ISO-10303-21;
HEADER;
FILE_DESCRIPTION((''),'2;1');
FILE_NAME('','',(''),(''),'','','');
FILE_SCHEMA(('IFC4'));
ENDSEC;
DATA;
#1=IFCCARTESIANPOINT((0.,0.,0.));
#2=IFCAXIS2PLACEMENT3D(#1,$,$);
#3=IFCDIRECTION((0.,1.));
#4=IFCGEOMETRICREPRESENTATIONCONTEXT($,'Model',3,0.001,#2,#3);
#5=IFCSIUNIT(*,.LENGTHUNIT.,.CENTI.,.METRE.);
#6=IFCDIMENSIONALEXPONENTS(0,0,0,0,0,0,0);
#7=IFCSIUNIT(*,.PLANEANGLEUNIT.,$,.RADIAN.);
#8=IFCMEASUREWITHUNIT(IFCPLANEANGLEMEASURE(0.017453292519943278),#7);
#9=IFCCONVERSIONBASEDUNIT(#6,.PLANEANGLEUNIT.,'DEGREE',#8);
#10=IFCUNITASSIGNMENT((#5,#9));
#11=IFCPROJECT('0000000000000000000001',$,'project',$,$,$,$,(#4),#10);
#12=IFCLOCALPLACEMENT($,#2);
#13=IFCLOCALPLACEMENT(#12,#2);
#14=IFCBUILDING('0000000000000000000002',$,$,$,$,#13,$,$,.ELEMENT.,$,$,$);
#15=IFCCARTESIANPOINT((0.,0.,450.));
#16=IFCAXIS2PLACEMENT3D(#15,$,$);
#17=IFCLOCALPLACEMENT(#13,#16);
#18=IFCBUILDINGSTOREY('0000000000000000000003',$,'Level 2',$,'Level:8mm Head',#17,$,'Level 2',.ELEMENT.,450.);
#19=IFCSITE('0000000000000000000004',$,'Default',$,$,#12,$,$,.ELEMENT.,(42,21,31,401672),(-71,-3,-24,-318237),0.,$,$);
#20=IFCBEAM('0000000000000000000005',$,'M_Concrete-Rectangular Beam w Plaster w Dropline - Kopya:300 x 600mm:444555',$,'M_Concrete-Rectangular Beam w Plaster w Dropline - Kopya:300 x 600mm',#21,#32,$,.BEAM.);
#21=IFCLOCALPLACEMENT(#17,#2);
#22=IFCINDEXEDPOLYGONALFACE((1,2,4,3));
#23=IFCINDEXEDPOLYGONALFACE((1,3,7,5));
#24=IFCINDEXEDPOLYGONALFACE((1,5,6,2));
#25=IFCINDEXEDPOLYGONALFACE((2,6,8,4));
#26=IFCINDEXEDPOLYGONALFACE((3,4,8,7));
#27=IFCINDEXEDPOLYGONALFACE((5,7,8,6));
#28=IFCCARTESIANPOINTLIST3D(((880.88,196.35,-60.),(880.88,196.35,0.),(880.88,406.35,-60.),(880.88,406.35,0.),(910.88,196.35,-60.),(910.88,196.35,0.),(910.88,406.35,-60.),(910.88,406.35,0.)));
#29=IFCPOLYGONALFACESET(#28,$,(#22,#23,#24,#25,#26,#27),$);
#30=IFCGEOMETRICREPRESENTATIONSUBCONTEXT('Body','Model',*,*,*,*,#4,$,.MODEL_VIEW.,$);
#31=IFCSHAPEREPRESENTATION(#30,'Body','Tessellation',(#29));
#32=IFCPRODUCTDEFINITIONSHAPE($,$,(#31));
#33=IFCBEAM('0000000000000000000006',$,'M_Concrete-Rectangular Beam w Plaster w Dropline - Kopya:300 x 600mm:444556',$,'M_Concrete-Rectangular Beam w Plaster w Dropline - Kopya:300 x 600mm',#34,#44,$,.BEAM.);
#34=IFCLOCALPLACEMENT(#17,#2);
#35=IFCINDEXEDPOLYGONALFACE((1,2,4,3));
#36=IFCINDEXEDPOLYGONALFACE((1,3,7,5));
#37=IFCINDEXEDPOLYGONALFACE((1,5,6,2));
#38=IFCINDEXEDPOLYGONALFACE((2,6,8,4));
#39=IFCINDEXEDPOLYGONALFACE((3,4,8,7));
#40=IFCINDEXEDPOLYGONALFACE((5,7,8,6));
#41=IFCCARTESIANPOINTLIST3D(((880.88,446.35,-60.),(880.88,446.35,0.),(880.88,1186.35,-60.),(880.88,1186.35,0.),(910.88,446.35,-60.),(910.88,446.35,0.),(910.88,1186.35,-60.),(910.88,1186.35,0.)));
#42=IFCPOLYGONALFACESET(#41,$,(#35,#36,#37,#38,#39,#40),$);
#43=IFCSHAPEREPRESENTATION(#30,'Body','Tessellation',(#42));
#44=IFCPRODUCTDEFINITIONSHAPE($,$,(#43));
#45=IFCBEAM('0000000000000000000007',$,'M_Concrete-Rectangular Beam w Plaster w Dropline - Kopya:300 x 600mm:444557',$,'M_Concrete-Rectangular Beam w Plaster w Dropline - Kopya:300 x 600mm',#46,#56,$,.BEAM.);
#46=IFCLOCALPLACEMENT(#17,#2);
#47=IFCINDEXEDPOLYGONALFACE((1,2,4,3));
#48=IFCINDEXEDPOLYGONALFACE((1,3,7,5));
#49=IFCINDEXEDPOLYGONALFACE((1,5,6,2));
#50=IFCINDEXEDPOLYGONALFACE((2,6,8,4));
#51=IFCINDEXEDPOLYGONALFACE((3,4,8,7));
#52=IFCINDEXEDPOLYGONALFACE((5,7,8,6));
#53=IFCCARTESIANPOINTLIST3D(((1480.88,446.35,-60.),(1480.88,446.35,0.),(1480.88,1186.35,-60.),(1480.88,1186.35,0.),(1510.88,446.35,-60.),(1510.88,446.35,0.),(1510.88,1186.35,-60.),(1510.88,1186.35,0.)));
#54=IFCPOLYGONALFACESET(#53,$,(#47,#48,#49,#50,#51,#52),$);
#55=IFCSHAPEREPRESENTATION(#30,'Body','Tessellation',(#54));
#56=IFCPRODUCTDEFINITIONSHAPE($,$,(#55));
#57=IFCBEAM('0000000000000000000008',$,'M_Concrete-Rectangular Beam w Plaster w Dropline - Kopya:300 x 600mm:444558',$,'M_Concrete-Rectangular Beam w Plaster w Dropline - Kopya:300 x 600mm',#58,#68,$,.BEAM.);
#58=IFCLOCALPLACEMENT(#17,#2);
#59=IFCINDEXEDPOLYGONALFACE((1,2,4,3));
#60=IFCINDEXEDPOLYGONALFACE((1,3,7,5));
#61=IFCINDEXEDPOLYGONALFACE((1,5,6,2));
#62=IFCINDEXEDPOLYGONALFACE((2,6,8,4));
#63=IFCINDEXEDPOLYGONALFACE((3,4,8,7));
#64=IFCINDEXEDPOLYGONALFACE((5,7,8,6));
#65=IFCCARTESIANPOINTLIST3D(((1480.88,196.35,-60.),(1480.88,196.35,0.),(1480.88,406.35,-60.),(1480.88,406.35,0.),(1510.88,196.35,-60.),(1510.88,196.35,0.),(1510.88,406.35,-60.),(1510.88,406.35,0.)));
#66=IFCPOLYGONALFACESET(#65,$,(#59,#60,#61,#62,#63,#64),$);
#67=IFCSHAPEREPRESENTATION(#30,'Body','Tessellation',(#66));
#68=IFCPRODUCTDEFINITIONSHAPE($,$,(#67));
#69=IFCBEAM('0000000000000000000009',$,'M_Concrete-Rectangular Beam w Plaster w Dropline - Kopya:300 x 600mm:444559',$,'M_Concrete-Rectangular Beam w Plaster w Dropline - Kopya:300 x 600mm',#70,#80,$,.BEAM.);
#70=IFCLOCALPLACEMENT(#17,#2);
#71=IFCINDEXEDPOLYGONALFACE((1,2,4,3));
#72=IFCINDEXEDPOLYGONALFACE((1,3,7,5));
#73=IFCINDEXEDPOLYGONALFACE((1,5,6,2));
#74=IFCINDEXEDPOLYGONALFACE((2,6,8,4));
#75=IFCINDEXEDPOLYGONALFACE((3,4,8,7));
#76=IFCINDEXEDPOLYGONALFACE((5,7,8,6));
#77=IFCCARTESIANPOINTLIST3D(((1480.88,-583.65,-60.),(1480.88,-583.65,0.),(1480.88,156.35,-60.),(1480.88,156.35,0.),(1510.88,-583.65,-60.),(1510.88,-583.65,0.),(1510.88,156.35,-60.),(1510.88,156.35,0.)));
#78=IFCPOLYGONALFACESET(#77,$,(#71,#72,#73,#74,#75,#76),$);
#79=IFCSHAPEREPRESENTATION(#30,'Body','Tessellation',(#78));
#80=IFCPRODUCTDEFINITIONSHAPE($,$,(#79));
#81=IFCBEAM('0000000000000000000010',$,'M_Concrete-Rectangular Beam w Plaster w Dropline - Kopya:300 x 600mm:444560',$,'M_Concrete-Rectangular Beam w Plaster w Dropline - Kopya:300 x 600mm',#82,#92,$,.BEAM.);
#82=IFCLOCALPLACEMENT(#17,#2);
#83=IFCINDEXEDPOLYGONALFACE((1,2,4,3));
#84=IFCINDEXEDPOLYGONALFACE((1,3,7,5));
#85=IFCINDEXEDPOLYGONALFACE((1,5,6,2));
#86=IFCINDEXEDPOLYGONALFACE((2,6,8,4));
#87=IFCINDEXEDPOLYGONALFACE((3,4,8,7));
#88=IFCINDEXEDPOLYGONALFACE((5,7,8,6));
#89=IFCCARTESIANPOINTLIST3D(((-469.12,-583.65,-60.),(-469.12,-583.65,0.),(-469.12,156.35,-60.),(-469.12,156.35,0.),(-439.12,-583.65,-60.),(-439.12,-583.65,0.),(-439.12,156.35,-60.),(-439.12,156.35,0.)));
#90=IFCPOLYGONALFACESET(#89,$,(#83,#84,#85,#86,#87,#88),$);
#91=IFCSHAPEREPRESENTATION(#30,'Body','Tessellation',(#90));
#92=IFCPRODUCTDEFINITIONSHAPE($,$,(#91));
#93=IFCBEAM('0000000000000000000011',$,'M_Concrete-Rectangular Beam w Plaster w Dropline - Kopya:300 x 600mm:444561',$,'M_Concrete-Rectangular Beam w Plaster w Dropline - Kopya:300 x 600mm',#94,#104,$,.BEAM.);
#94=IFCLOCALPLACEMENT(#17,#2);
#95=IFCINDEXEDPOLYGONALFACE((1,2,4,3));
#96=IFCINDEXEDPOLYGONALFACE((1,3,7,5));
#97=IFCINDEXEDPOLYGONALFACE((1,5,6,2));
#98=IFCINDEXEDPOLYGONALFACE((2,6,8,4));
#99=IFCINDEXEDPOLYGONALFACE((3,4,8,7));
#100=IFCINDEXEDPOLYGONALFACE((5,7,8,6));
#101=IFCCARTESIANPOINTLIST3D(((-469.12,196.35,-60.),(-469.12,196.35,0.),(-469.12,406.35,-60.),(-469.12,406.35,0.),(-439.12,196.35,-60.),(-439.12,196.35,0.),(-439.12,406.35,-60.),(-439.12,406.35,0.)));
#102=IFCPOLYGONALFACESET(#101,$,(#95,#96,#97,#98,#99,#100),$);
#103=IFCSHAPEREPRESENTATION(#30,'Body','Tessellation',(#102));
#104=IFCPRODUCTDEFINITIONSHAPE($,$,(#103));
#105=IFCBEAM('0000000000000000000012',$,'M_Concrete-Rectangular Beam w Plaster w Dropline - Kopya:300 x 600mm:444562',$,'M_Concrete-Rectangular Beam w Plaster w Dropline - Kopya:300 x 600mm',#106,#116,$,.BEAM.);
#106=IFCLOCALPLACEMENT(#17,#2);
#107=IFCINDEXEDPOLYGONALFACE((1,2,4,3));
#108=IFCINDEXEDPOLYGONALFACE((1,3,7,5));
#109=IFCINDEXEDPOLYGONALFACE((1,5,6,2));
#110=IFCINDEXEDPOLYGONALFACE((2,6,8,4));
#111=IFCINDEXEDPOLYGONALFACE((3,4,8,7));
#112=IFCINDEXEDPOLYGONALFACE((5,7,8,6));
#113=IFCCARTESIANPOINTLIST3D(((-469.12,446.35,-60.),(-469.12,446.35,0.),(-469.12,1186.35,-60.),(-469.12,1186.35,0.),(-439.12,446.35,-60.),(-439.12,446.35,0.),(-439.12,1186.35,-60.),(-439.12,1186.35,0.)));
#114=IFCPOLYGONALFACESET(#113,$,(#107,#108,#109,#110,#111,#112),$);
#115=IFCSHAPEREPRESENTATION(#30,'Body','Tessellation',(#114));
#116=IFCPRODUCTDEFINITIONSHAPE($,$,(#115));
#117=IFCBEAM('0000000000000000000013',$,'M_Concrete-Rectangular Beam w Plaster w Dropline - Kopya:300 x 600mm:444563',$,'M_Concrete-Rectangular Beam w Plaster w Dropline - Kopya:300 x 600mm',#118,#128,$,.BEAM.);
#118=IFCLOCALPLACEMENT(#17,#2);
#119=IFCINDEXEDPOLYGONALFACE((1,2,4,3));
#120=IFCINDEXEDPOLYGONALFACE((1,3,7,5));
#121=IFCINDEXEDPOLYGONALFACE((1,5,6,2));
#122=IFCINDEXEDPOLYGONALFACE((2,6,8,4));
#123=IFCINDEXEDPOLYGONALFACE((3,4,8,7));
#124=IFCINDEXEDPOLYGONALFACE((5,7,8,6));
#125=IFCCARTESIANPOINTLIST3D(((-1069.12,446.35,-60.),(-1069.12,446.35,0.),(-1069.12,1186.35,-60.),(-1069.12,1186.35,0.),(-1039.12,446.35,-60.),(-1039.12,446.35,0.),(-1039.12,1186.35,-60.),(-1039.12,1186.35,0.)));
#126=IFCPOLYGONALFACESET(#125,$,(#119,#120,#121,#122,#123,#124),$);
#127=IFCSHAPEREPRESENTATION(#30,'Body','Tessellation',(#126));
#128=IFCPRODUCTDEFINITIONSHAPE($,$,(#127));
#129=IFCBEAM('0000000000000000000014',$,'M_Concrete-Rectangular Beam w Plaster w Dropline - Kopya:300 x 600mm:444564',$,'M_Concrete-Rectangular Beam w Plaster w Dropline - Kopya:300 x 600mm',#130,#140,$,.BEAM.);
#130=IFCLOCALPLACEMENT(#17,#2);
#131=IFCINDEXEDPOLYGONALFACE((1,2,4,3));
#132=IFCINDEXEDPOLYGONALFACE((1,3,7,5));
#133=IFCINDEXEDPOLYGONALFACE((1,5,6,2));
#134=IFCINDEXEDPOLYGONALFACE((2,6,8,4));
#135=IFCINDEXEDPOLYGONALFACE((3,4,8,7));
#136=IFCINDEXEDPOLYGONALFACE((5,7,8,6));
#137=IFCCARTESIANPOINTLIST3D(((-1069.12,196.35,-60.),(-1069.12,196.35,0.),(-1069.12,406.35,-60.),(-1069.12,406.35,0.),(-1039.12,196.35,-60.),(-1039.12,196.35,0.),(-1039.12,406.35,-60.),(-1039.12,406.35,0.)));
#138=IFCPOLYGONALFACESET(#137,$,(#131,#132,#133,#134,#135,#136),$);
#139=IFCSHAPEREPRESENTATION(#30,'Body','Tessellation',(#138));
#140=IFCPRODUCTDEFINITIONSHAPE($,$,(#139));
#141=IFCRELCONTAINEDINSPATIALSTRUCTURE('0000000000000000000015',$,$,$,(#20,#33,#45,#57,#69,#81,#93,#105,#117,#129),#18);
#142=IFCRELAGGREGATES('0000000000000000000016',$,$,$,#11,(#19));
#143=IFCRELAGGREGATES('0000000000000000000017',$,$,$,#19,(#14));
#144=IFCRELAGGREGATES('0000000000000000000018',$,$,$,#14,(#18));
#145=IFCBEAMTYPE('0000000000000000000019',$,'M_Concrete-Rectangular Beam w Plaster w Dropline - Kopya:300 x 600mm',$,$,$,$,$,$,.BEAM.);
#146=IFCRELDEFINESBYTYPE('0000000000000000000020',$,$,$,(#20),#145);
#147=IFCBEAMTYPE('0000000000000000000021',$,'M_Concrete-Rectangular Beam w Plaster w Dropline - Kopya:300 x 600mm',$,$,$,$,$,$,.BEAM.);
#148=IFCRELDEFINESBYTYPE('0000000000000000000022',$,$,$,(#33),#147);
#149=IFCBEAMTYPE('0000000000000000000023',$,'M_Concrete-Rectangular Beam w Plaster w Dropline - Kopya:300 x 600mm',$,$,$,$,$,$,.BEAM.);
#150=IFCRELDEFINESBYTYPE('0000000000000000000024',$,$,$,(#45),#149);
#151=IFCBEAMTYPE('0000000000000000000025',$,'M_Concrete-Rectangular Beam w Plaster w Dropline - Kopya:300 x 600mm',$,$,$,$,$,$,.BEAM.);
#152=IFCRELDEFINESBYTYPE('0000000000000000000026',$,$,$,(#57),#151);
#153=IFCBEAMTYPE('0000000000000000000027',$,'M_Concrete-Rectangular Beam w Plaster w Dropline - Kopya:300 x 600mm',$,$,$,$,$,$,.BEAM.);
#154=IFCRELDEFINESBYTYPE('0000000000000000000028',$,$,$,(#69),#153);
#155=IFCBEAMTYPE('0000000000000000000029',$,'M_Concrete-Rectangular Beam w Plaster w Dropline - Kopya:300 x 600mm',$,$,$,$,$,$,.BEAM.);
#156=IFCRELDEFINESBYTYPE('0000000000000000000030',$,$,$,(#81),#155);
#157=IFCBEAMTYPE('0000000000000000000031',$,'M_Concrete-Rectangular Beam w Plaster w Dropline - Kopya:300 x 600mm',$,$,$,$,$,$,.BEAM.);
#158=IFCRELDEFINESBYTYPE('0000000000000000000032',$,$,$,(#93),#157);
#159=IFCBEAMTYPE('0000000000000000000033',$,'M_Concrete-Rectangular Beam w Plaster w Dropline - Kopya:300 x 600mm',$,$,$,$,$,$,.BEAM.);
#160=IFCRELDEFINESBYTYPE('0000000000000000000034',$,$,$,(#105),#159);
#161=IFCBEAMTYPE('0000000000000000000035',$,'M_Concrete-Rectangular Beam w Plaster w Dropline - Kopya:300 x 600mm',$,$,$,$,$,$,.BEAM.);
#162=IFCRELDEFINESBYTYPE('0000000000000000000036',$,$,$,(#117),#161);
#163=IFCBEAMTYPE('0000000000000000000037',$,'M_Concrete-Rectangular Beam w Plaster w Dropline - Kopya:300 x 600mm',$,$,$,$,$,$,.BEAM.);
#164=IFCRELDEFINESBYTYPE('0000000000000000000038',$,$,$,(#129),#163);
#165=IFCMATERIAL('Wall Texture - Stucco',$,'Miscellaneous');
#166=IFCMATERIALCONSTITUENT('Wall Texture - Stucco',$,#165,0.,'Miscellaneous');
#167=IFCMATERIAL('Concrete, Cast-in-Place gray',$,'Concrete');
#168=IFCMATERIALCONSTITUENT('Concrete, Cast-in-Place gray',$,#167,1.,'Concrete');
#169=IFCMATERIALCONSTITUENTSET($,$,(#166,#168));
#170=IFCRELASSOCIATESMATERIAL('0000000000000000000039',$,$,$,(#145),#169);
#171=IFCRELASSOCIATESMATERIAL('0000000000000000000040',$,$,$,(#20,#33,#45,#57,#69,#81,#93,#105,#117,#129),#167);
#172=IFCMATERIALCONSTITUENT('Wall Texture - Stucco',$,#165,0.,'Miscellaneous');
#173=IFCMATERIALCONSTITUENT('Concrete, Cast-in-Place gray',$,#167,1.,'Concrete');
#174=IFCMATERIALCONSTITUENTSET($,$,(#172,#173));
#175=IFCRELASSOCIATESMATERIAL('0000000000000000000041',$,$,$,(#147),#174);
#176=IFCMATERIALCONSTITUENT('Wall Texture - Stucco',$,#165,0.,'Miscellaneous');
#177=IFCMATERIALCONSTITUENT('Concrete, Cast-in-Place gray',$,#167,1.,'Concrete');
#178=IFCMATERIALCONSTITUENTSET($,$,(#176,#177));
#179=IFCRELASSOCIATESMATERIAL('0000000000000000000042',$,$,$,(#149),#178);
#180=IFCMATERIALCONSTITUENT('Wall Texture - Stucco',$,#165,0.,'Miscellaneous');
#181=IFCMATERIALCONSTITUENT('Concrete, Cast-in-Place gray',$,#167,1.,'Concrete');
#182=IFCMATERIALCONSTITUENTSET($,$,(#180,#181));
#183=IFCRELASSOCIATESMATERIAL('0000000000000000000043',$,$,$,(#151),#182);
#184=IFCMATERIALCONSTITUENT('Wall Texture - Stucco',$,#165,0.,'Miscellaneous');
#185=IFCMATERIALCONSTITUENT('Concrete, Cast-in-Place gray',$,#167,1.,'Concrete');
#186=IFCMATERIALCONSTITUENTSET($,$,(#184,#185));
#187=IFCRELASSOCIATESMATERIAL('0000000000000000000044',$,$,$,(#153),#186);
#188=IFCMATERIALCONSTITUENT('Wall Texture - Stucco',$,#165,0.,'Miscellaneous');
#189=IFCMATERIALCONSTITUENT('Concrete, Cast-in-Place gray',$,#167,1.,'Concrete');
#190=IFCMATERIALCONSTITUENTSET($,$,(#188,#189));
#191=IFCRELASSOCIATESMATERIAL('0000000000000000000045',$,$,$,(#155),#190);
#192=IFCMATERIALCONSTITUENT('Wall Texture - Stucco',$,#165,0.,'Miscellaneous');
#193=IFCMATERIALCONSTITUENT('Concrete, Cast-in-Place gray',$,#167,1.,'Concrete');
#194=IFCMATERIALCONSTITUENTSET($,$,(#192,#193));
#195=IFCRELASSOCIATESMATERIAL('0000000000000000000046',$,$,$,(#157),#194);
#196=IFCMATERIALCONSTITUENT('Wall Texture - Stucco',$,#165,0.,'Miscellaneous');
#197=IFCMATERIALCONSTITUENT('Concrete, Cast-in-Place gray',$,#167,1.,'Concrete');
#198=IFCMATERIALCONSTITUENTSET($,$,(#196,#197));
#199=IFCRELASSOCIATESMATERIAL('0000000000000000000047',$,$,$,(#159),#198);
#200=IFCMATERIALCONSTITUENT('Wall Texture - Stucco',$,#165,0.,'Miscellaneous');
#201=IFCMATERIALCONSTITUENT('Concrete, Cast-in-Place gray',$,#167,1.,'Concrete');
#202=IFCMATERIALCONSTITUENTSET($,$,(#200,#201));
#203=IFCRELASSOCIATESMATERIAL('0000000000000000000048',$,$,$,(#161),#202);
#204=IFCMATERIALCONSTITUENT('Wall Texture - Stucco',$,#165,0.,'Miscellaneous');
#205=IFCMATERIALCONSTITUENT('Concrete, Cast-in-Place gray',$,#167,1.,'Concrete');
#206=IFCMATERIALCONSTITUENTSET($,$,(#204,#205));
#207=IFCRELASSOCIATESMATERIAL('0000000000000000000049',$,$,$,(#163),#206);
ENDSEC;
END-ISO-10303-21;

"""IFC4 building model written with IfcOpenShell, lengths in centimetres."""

from ifc_helpers import new_model, entity, si_unit, converted_unit, direction, frame, origin, place, context, subcontext, project, spatial, indexed_curve, outline, extrude, source, transform, mapped, material, constituent, constituent_set, type_object, type_shapes, element, save


model = new_model("IFC4")

# Units and contexts
model_context = context("Model", 3, precision=0.001, world=origin(), true_north=direction((0.0, 1.0)))
body_context = subcontext(model_context, "Body", "Model", "MODEL_VIEW")
ifc_project = project(units=[si_unit("LENGTHUNIT", "METRE", prefix="CENTI"), converted_unit("PLANEANGLEUNIT", "DEGREE", entity("IfcPlaneAngleMeasure", 0.017453292519943278), si_unit("PLANEANGLEUNIT", "RADIAN"), dimensions=[0, 0, 0, 0, 0, 0, 0])], contexts=[model_context])

# Site, building, storey
site_placement = place(None, origin())
site = spatial("IfcSite", under=ifc_project, at=site_placement, Name="Default", CompositionType="ELEMENT", RefLatitude=(42, 21, 31, 401672), RefLongitude=(-71, -3, -24, -318237), RefElevation=0.0)
building_placement = place(site_placement, origin())
building = spatial("IfcBuilding", under=site, at=building_placement, CompositionType="ELEMENT")
storey_placement = place(building_placement, frame((0.0, 0.0, 450.0)))
storey = spatial("IfcBuildingStorey", under=building, at=storey_placement, Name="Level 2", ObjectType="Level:8mm Head", LongName="Level 2", CompositionType="ELEMENT", Elevation=450.0)

# Beams
ifc_material_1 = material(Name="Concrete, Cast-in-Place gray", Category="Concrete")
ifc_material_2 = material(Name="Wall Texture - Stucco", Category="Miscellaneous")
ifc_constituent_1 = constituent(ifc_material_2, Name="Wall Texture - Stucco", Category="Miscellaneous", fraction=0.0)
ifc_constituent_2 = constituent(ifc_material_1, Name="Concrete, Cast-in-Place gray", Category="Concrete", fraction=1.0)
ifc_constituent_set_1 = constituent_set(constituents=[ifc_constituent_1, ifc_constituent_2])
beam_type_1 = type_object("IfcBeamType", Name="M_Concrete-Rectangular Beam w Plaster w Dropline - Kopya:300 x 600mm", PredefinedType="BEAM", material=ifc_constituent_set_1)
shared_shape_1 = source(origin(), body_context, "Body", "SweptSolid", [
    extrude(outline(indexed_curve([(-15.0, -30.0), (15.0, -30.0), (15.0, 30.0), (-15.0, 30.0), (-15.0, -30.0)], self_intersect=False)), frame((895.88, 196.35, 420.0), z_axis=(0.0, 1.0, 0.0), x_axis=(-1.0, 0.0, 0.0)), (0.0, 0.0, 1.0), 210.0),
])
type_shapes(beam_type_1, [shared_shape_1])
beam_1_placement = place(storey_placement, frame((0.0, 0.0, -450.0)))
element("IfcBeam", 1, at=beam_1_placement, inside=storey, type_object=beam_type_1, material=ifc_material_1, Name="M_Concrete-Rectangular Beam w Plaster w Dropline - Kopya:300 x 600mm:444555", ObjectType="M_Concrete-Rectangular Beam w Plaster w Dropline - Kopya:300 x 600mm", PredefinedType="BEAM", context=body_context, shape_type="MappedRepresentation", body=[
    mapped(shared_shape_1, transform((0.0, 0.0, 0.0), scale=1.0)),
])
ifc_constituent_3 = constituent(ifc_material_2, Name="Wall Texture - Stucco", Category="Miscellaneous", fraction=0.0)
ifc_constituent_4 = constituent(ifc_material_1, Name="Concrete, Cast-in-Place gray", Category="Concrete", fraction=1.0)
ifc_constituent_set_2 = constituent_set(constituents=[ifc_constituent_3, ifc_constituent_4])
beam_type_2 = type_object("IfcBeamType", Name="M_Concrete-Rectangular Beam w Plaster w Dropline - Kopya:300 x 600mm", PredefinedType="BEAM", material=ifc_constituent_set_2)
shared_shape_2 = source(origin(), body_context, "Body", "SweptSolid", [
    extrude(outline(indexed_curve([(-15.0, -30.0), (15.0, -30.0), (15.0, 30.0), (-15.0, 30.0), (-15.0, -30.0)], self_intersect=False)), frame((895.88, 446.35, 420.0), z_axis=(0.0, 1.0, 0.0), x_axis=(-1.0, 0.0, 0.0)), (0.0, 0.0, 1.0), 740.0),
])
type_shapes(beam_type_2, [shared_shape_2])
beam_2_placement = place(storey_placement, frame((0.0, 0.0, -450.0)))
element("IfcBeam", 2, at=beam_2_placement, inside=storey, type_object=beam_type_2, material=ifc_material_1, Name="M_Concrete-Rectangular Beam w Plaster w Dropline - Kopya:300 x 600mm:444556", ObjectType="M_Concrete-Rectangular Beam w Plaster w Dropline - Kopya:300 x 600mm", PredefinedType="BEAM", context=body_context, shape_type="MappedRepresentation", body=[
    mapped(shared_shape_2, transform((0.0, 0.0, 0.0), scale=1.0)),
])
ifc_constituent_5 = constituent(ifc_material_2, Name="Wall Texture - Stucco", Category="Miscellaneous", fraction=0.0)
ifc_constituent_6 = constituent(ifc_material_1, Name="Concrete, Cast-in-Place gray", Category="Concrete", fraction=1.0)
ifc_constituent_set_3 = constituent_set(constituents=[ifc_constituent_5, ifc_constituent_6])
beam_type_3 = type_object("IfcBeamType", Name="M_Concrete-Rectangular Beam w Plaster w Dropline - Kopya:300 x 600mm", PredefinedType="BEAM", material=ifc_constituent_set_3)
shared_shape_3 = source(origin(), body_context, "Body", "SweptSolid", [
    extrude(outline(indexed_curve([(-15.0, -30.0), (15.0, -30.0), (15.0, 30.0), (-15.0, 30.0), (-15.0, -30.0)], self_intersect=False)), frame((1495.88, 1186.35, 420.0), z_axis=(0.0, -1.0, 0.0), x_axis=(-1.0, 0.0, 0.0)), (0.0, 0.0, 1.0), 740.0),
])
type_shapes(beam_type_3, [shared_shape_3])
beam_3_placement = place(storey_placement, frame((0.0, 0.0, -450.0)))
element("IfcBeam", 3, at=beam_3_placement, inside=storey, type_object=beam_type_3, material=ifc_material_1, Name="M_Concrete-Rectangular Beam w Plaster w Dropline - Kopya:300 x 600mm:444557", ObjectType="M_Concrete-Rectangular Beam w Plaster w Dropline - Kopya:300 x 600mm", PredefinedType="BEAM", context=body_context, shape_type="MappedRepresentation", body=[
    mapped(shared_shape_3, transform((0.0, 0.0, 0.0), scale=1.0)),
])
ifc_constituent_7 = constituent(ifc_material_2, Name="Wall Texture - Stucco", Category="Miscellaneous", fraction=0.0)
ifc_constituent_8 = constituent(ifc_material_1, Name="Concrete, Cast-in-Place gray", Category="Concrete", fraction=1.0)
ifc_constituent_set_4 = constituent_set(constituents=[ifc_constituent_7, ifc_constituent_8])
beam_type_4 = type_object("IfcBeamType", Name="M_Concrete-Rectangular Beam w Plaster w Dropline - Kopya:300 x 600mm", PredefinedType="BEAM", material=ifc_constituent_set_4)
shared_shape_4 = source(origin(), body_context, "Body", "SweptSolid", [
    extrude(outline(indexed_curve([(-15.0, -30.0), (15.0, -30.0), (15.0, 30.0), (-15.0, 30.0), (-15.0, -30.0)], self_intersect=False)), frame((1495.88, 406.35, 420.0), z_axis=(0.0, -1.0, 0.0), x_axis=(-1.0, 0.0, 0.0)), (0.0, 0.0, 1.0), 210.0),
])
type_shapes(beam_type_4, [shared_shape_4])
beam_4_placement = place(storey_placement, frame((0.0, 0.0, -450.0)))
element("IfcBeam", 4, at=beam_4_placement, inside=storey, type_object=beam_type_4, material=ifc_material_1, Name="M_Concrete-Rectangular Beam w Plaster w Dropline - Kopya:300 x 600mm:444558", ObjectType="M_Concrete-Rectangular Beam w Plaster w Dropline - Kopya:300 x 600mm", PredefinedType="BEAM", context=body_context, shape_type="MappedRepresentation", body=[
    mapped(shared_shape_4, transform((0.0, 0.0, 0.0), scale=1.0)),
])
ifc_constituent_9 = constituent(ifc_material_2, Name="Wall Texture - Stucco", Category="Miscellaneous", fraction=0.0)
ifc_constituent_10 = constituent(ifc_material_1, Name="Concrete, Cast-in-Place gray", Category="Concrete", fraction=1.0)
ifc_constituent_set_5 = constituent_set(constituents=[ifc_constituent_9, ifc_constituent_10])
beam_type_5 = type_object("IfcBeamType", Name="M_Concrete-Rectangular Beam w Plaster w Dropline - Kopya:300 x 600mm", PredefinedType="BEAM", material=ifc_constituent_set_5)
shared_shape_5 = source(origin(), body_context, "Body", "SweptSolid", [
    extrude(outline(indexed_curve([(-15.0, -30.0), (15.0, -30.0), (15.0, 30.0), (-15.0, 30.0), (-15.0, -30.0)], self_intersect=False)), frame((1495.88, 156.35, 420.0), z_axis=(0.0, -1.0, 0.0), x_axis=(-1.0, 0.0, 0.0)), (0.0, 0.0, 1.0), 740.0),
])
type_shapes(beam_type_5, [shared_shape_5])
beam_5_placement = place(storey_placement, frame((0.0, 0.0, -450.0)))
element("IfcBeam", 5, at=beam_5_placement, inside=storey, type_object=beam_type_5, material=ifc_material_1, Name="M_Concrete-Rectangular Beam w Plaster w Dropline - Kopya:300 x 600mm:444559", ObjectType="M_Concrete-Rectangular Beam w Plaster w Dropline - Kopya:300 x 600mm", PredefinedType="BEAM", context=body_context, shape_type="MappedRepresentation", body=[
    mapped(shared_shape_5, transform((0.0, 0.0, 0.0), scale=1.0)),
])
ifc_constituent_11 = constituent(ifc_material_2, Name="Wall Texture - Stucco", Category="Miscellaneous", fraction=0.0)
ifc_constituent_12 = constituent(ifc_material_1, Name="Concrete, Cast-in-Place gray", Category="Concrete", fraction=1.0)
ifc_constituent_set_6 = constituent_set(constituents=[ifc_constituent_11, ifc_constituent_12])
beam_type_6 = type_object("IfcBeamType", Name="M_Concrete-Rectangular Beam w Plaster w Dropline - Kopya:300 x 600mm", PredefinedType="BEAM", material=ifc_constituent_set_6)
shared_shape_6 = source(origin(), body_context, "Body", "SweptSolid", [
    extrude(outline(indexed_curve([(-15.0, -30.0), (15.0, -30.0), (15.0, 30.0), (-15.0, 30.0), (-15.0, -30.0)], self_intersect=False)), frame((-454.12, -583.65, 420.0), z_axis=(0.0, 1.0, 0.0), x_axis=(-1.0, 0.0, 0.0)), (0.0, 0.0, 1.0), 740.0),
])
type_shapes(beam_type_6, [shared_shape_6])
beam_6_placement = place(storey_placement, frame((0.0, 0.0, -450.0)))
element("IfcBeam", 6, at=beam_6_placement, inside=storey, type_object=beam_type_6, material=ifc_material_1, Name="M_Concrete-Rectangular Beam w Plaster w Dropline - Kopya:300 x 600mm:444560", ObjectType="M_Concrete-Rectangular Beam w Plaster w Dropline - Kopya:300 x 600mm", PredefinedType="BEAM", context=body_context, shape_type="MappedRepresentation", body=[
    mapped(shared_shape_6, transform((0.0, 0.0, 0.0), scale=1.0)),
])
ifc_constituent_13 = constituent(ifc_material_2, Name="Wall Texture - Stucco", Category="Miscellaneous", fraction=0.0)
ifc_constituent_14 = constituent(ifc_material_1, Name="Concrete, Cast-in-Place gray", Category="Concrete", fraction=1.0)
ifc_constituent_set_7 = constituent_set(constituents=[ifc_constituent_13, ifc_constituent_14])
beam_type_7 = type_object("IfcBeamType", Name="M_Concrete-Rectangular Beam w Plaster w Dropline - Kopya:300 x 600mm", PredefinedType="BEAM", material=ifc_constituent_set_7)
shared_shape_7 = source(origin(), body_context, "Body", "SweptSolid", [
    extrude(outline(indexed_curve([(-15.0, -30.0), (15.0, -30.0), (15.0, 30.0), (-15.0, 30.0), (-15.0, -30.0)], self_intersect=False)), frame((-454.12, 196.35, 420.0), z_axis=(0.0, 1.0, 0.0), x_axis=(-1.0, 0.0, 0.0)), (0.0, 0.0, 1.0), 210.0),
])
type_shapes(beam_type_7, [shared_shape_7])
beam_7_placement = place(storey_placement, frame((0.0, 0.0, -450.0)))
element("IfcBeam", 7, at=beam_7_placement, inside=storey, type_object=beam_type_7, material=ifc_material_1, Name="M_Concrete-Rectangular Beam w Plaster w Dropline - Kopya:300 x 600mm:444561", ObjectType="M_Concrete-Rectangular Beam w Plaster w Dropline - Kopya:300 x 600mm", PredefinedType="BEAM", context=body_context, shape_type="MappedRepresentation", body=[
    mapped(shared_shape_7, transform((0.0, 0.0, 0.0), scale=1.0)),
])
ifc_constituent_15 = constituent(ifc_material_2, Name="Wall Texture - Stucco", Category="Miscellaneous", fraction=0.0)
ifc_constituent_16 = constituent(ifc_material_1, Name="Concrete, Cast-in-Place gray", Category="Concrete", fraction=1.0)
ifc_constituent_set_8 = constituent_set(constituents=[ifc_constituent_15, ifc_constituent_16])
beam_type_8 = type_object("IfcBeamType", Name="M_Concrete-Rectangular Beam w Plaster w Dropline - Kopya:300 x 600mm", PredefinedType="BEAM", material=ifc_constituent_set_8)
shared_shape_8 = source(origin(), body_context, "Body", "SweptSolid", [
    extrude(outline(indexed_curve([(-15.0, -30.0), (15.0, -30.0), (15.0, 30.0), (-15.0, 30.0), (-15.0, -30.0)], self_intersect=False)), frame((-454.12, 446.35, 420.0), z_axis=(0.0, 1.0, 0.0), x_axis=(-1.0, 0.0, 0.0)), (0.0, 0.0, 1.0), 740.0),
])
type_shapes(beam_type_8, [shared_shape_8])
beam_8_placement = place(storey_placement, frame((0.0, 0.0, -450.0)))
element("IfcBeam", 8, at=beam_8_placement, inside=storey, type_object=beam_type_8, material=ifc_material_1, Name="M_Concrete-Rectangular Beam w Plaster w Dropline - Kopya:300 x 600mm:444562", ObjectType="M_Concrete-Rectangular Beam w Plaster w Dropline - Kopya:300 x 600mm", PredefinedType="BEAM", context=body_context, shape_type="MappedRepresentation", body=[
    mapped(shared_shape_8, transform((0.0, 0.0, 0.0), scale=1.0)),
])
ifc_constituent_17 = constituent(ifc_material_2, Name="Wall Texture - Stucco", Category="Miscellaneous", fraction=0.0)
ifc_constituent_18 = constituent(ifc_material_1, Name="Concrete, Cast-in-Place gray", Category="Concrete", fraction=1.0)
ifc_constituent_set_9 = constituent_set(constituents=[ifc_constituent_17, ifc_constituent_18])
beam_type_9 = type_object("IfcBeamType", Name="M_Concrete-Rectangular Beam w Plaster w Dropline - Kopya:300 x 600mm", PredefinedType="BEAM", material=ifc_constituent_set_9)
shared_shape_9 = source(origin(), body_context, "Body", "SweptSolid", [
    extrude(outline(indexed_curve([(-15.0, -30.0), (15.0, -30.0), (15.0, 30.0), (-15.0, 30.0), (-15.0, -30.0)], self_intersect=False)), frame((-1054.12, 1186.35, 420.0), z_axis=(0.0, -1.0, 0.0), x_axis=(-1.0, 0.0, 0.0)), (0.0, 0.0, 1.0), 740.0),
])
type_shapes(beam_type_9, [shared_shape_9])
beam_9_placement = place(storey_placement, frame((0.0, 0.0, -450.0)))
element("IfcBeam", 9, at=beam_9_placement, inside=storey, type_object=beam_type_9, material=ifc_material_1, Name="M_Concrete-Rectangular Beam w Plaster w Dropline - Kopya:300 x 600mm:444563", ObjectType="M_Concrete-Rectangular Beam w Plaster w Dropline - Kopya:300 x 600mm", PredefinedType="BEAM", context=body_context, shape_type="MappedRepresentation", body=[
    mapped(shared_shape_9, transform((0.0, 0.0, 0.0), scale=1.0)),
])
ifc_constituent_19 = constituent(ifc_material_2, Name="Wall Texture - Stucco", Category="Miscellaneous", fraction=0.0)
ifc_constituent_20 = constituent(ifc_material_1, Name="Concrete, Cast-in-Place gray", Category="Concrete", fraction=1.0)
ifc_constituent_set_10 = constituent_set(constituents=[ifc_constituent_19, ifc_constituent_20])
beam_type_10 = type_object("IfcBeamType", Name="M_Concrete-Rectangular Beam w Plaster w Dropline - Kopya:300 x 600mm", PredefinedType="BEAM", material=ifc_constituent_set_10)
shared_shape_10 = source(origin(), body_context, "Body", "SweptSolid", [
    extrude(outline(indexed_curve([(-15.0, -30.0), (15.0, -30.0), (15.0, 30.0), (-15.0, 30.0), (-15.0, -30.0)], self_intersect=False)), frame((-1054.12, 406.35, 420.0), z_axis=(0.0, -1.0, 0.0), x_axis=(-1.0, 0.0, 0.0)), (0.0, 0.0, 1.0), 210.0),
])
type_shapes(beam_type_10, [shared_shape_10])
beam_10_placement = place(storey_placement, frame((0.0, 0.0, -450.0)))
element("IfcBeam", 10, at=beam_10_placement, inside=storey, type_object=beam_type_10, material=ifc_material_1, Name="M_Concrete-Rectangular Beam w Plaster w Dropline - Kopya:300 x 600mm:444564", ObjectType="M_Concrete-Rectangular Beam w Plaster w Dropline - Kopya:300 x 600mm", PredefinedType="BEAM", context=body_context, shape_type="MappedRepresentation", body=[
    mapped(shared_shape_10, transform((0.0, 0.0, 0.0), scale=1.0)),
])

save(model, "model.ifc")
